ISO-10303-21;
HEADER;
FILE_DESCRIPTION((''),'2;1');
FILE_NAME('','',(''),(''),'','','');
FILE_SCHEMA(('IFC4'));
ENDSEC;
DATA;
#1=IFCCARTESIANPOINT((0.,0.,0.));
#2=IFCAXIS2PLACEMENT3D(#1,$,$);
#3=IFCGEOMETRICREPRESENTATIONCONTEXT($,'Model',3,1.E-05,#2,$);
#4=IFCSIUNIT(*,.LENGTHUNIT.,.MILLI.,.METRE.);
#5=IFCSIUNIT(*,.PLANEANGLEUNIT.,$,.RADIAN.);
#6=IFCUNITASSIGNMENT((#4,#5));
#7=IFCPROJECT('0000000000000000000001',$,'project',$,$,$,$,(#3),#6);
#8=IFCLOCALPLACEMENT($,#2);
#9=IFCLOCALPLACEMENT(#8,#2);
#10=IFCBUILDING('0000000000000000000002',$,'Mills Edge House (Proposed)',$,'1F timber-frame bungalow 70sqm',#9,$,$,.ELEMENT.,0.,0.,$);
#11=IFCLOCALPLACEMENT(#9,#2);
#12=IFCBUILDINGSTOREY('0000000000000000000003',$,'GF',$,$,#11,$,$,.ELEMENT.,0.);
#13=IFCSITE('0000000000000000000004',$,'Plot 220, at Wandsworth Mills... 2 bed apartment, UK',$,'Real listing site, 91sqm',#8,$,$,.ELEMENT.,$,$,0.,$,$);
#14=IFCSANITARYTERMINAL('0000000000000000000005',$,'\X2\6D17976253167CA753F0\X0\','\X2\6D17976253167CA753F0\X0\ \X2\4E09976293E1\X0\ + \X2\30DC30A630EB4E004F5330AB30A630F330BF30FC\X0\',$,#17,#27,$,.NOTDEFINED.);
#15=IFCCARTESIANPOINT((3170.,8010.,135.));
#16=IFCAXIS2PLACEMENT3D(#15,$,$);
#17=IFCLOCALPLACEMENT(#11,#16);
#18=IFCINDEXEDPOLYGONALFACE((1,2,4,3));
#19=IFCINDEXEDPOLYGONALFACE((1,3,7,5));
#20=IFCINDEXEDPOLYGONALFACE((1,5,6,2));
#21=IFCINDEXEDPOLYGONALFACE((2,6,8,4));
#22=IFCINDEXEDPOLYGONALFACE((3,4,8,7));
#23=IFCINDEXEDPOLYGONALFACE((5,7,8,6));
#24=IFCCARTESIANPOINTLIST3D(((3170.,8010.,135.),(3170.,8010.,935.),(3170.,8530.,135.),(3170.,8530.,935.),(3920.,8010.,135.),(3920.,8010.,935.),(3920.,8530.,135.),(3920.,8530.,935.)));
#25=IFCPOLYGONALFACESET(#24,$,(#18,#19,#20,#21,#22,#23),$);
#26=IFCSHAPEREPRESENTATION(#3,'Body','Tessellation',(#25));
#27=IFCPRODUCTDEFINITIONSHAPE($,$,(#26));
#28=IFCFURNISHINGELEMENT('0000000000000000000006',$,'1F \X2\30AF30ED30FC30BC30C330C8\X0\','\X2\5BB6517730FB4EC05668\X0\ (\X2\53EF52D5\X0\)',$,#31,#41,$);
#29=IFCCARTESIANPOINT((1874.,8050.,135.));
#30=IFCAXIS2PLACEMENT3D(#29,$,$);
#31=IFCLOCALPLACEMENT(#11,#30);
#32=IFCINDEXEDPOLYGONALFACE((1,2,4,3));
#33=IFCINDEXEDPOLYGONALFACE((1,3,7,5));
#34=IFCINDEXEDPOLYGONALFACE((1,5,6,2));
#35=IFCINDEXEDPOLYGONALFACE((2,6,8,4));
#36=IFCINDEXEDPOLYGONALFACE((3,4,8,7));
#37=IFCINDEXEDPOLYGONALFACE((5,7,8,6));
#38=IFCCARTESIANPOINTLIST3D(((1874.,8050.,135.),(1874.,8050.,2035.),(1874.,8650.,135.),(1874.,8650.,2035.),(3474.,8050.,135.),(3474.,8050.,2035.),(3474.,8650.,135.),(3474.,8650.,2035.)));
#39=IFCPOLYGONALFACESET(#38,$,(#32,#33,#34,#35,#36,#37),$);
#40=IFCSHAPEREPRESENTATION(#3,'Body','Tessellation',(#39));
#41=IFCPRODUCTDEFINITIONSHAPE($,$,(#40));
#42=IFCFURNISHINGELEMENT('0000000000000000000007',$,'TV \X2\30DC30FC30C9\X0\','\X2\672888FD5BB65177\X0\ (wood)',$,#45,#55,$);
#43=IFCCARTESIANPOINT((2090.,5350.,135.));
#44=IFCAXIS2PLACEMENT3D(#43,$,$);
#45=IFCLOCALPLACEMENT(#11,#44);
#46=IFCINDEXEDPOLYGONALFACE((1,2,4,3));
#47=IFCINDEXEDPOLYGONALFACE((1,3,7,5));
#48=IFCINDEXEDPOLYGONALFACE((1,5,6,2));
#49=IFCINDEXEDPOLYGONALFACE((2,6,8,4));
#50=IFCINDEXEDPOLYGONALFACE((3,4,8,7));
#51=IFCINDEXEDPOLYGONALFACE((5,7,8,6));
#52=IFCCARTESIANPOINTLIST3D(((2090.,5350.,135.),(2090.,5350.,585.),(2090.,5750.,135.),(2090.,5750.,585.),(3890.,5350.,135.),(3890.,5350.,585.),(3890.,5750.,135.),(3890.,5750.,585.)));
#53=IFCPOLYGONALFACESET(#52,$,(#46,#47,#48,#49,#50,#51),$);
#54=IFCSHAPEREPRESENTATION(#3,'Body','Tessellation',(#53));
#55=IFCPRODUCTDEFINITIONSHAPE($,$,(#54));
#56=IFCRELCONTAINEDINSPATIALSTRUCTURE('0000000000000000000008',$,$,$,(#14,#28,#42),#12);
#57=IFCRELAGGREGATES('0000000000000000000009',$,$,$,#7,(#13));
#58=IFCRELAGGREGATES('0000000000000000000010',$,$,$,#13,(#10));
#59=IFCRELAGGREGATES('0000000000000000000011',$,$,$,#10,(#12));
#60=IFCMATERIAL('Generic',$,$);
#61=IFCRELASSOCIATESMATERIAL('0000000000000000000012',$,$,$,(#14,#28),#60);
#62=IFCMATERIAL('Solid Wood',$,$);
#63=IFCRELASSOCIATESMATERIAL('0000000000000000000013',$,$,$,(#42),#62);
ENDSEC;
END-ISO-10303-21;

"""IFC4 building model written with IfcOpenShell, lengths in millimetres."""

from ifc_helpers import new_model, si_unit, frame, frame_2d, origin, place, context, project, spatial, rectangle, extrude, material, element, save


model = new_model("IFC4")

# Units and contexts
model_context = context("Model", 3, precision=1e-05, world=origin())
ifc_project = project(units=[si_unit("LENGTHUNIT", "METRE", prefix="MILLI"), si_unit("PLANEANGLEUNIT", "RADIAN")], contexts=[model_context])

# Site, building, storey
site_placement = place(None, origin())
site = spatial("IfcSite", under=ifc_project, at=site_placement, Name="Plot 220, at Wandsworth Mills... 2 bed apartment, UK", ObjectType="Real listing site, 91sqm", CompositionType="ELEMENT", RefElevation=0.0)
building_placement = place(site_placement, origin())
building = spatial("IfcBuilding", under=site, at=building_placement, Name="Mills Edge House (Proposed)", ObjectType="1F timber-frame bungalow 70sqm", CompositionType="ELEMENT", ElevationOfRefHeight=0.0, ElevationOfTerrain=0.0)
storey_placement = place(building_placement, origin())
storey = spatial("IfcBuildingStorey", under=building, at=storey_placement, Name="GF", CompositionType="ELEMENT", Elevation=0.0)

# Shared definitions
ifc_material_1 = material(Name="Solid Wood")

# Shared definitions
ifc_material_2 = material(Name="Generic")

# Sanitary terminal
sanitary_terminal_1_placement = place(storey_placement, frame((3170.0, 8010.0, 135.0)))
element("IfcSanitaryTerminal", 1, at=sanitary_terminal_1_placement, inside=storey, material=ifc_material_2, Name="洗面化粧台", Description="洗面化粧台 三面鏡 + ボウル一体カウンター", PredefinedType="NOTDEFINED", context=model_context, shape_type="SweptSolid", body=[
    extrude(rectangle(XDim=750.0, YDim=520.0, at=frame_2d((375.0, 260.0))), frame((3170.0, 8010.0, 135.0)), (0.0, 0.0, 1.0), 800.0),
])

# Furnishing elements
furnishing_1_placement = place(storey_placement, frame((1874.0, 8050.0, 135.0)))
element("IfcFurnishingElement", 2, at=furnishing_1_placement, inside=storey, material=ifc_material_2, Name="1F クローゼット", Description="家具・什器 (可動)", context=model_context, shape_type="SweptSolid", body=[
    extrude(rectangle(XDim=1600.0, YDim=600.0, at=frame_2d((800.0, 300.0))), frame((1874.0, 8050.0, 135.0)), (0.0, 0.0, 1.0), 1900.0),
])
furnishing_2_placement = place(storey_placement, frame((2090.0, 5350.0, 135.0)))
element("IfcFurnishingElement", 3, at=furnishing_2_placement, inside=storey, material=ifc_material_1, Name="TV ボード", Description="木製家具 (wood)", context=model_context, shape_type="SweptSolid", body=[
    extrude(rectangle(XDim=1800.0, YDim=400.0, at=frame_2d((900.0, 200.0))), frame((2090.0, 5350.0, 135.0)), (0.0, 0.0, 1.0), 450.0),
])

save(model, "model.ifc")
